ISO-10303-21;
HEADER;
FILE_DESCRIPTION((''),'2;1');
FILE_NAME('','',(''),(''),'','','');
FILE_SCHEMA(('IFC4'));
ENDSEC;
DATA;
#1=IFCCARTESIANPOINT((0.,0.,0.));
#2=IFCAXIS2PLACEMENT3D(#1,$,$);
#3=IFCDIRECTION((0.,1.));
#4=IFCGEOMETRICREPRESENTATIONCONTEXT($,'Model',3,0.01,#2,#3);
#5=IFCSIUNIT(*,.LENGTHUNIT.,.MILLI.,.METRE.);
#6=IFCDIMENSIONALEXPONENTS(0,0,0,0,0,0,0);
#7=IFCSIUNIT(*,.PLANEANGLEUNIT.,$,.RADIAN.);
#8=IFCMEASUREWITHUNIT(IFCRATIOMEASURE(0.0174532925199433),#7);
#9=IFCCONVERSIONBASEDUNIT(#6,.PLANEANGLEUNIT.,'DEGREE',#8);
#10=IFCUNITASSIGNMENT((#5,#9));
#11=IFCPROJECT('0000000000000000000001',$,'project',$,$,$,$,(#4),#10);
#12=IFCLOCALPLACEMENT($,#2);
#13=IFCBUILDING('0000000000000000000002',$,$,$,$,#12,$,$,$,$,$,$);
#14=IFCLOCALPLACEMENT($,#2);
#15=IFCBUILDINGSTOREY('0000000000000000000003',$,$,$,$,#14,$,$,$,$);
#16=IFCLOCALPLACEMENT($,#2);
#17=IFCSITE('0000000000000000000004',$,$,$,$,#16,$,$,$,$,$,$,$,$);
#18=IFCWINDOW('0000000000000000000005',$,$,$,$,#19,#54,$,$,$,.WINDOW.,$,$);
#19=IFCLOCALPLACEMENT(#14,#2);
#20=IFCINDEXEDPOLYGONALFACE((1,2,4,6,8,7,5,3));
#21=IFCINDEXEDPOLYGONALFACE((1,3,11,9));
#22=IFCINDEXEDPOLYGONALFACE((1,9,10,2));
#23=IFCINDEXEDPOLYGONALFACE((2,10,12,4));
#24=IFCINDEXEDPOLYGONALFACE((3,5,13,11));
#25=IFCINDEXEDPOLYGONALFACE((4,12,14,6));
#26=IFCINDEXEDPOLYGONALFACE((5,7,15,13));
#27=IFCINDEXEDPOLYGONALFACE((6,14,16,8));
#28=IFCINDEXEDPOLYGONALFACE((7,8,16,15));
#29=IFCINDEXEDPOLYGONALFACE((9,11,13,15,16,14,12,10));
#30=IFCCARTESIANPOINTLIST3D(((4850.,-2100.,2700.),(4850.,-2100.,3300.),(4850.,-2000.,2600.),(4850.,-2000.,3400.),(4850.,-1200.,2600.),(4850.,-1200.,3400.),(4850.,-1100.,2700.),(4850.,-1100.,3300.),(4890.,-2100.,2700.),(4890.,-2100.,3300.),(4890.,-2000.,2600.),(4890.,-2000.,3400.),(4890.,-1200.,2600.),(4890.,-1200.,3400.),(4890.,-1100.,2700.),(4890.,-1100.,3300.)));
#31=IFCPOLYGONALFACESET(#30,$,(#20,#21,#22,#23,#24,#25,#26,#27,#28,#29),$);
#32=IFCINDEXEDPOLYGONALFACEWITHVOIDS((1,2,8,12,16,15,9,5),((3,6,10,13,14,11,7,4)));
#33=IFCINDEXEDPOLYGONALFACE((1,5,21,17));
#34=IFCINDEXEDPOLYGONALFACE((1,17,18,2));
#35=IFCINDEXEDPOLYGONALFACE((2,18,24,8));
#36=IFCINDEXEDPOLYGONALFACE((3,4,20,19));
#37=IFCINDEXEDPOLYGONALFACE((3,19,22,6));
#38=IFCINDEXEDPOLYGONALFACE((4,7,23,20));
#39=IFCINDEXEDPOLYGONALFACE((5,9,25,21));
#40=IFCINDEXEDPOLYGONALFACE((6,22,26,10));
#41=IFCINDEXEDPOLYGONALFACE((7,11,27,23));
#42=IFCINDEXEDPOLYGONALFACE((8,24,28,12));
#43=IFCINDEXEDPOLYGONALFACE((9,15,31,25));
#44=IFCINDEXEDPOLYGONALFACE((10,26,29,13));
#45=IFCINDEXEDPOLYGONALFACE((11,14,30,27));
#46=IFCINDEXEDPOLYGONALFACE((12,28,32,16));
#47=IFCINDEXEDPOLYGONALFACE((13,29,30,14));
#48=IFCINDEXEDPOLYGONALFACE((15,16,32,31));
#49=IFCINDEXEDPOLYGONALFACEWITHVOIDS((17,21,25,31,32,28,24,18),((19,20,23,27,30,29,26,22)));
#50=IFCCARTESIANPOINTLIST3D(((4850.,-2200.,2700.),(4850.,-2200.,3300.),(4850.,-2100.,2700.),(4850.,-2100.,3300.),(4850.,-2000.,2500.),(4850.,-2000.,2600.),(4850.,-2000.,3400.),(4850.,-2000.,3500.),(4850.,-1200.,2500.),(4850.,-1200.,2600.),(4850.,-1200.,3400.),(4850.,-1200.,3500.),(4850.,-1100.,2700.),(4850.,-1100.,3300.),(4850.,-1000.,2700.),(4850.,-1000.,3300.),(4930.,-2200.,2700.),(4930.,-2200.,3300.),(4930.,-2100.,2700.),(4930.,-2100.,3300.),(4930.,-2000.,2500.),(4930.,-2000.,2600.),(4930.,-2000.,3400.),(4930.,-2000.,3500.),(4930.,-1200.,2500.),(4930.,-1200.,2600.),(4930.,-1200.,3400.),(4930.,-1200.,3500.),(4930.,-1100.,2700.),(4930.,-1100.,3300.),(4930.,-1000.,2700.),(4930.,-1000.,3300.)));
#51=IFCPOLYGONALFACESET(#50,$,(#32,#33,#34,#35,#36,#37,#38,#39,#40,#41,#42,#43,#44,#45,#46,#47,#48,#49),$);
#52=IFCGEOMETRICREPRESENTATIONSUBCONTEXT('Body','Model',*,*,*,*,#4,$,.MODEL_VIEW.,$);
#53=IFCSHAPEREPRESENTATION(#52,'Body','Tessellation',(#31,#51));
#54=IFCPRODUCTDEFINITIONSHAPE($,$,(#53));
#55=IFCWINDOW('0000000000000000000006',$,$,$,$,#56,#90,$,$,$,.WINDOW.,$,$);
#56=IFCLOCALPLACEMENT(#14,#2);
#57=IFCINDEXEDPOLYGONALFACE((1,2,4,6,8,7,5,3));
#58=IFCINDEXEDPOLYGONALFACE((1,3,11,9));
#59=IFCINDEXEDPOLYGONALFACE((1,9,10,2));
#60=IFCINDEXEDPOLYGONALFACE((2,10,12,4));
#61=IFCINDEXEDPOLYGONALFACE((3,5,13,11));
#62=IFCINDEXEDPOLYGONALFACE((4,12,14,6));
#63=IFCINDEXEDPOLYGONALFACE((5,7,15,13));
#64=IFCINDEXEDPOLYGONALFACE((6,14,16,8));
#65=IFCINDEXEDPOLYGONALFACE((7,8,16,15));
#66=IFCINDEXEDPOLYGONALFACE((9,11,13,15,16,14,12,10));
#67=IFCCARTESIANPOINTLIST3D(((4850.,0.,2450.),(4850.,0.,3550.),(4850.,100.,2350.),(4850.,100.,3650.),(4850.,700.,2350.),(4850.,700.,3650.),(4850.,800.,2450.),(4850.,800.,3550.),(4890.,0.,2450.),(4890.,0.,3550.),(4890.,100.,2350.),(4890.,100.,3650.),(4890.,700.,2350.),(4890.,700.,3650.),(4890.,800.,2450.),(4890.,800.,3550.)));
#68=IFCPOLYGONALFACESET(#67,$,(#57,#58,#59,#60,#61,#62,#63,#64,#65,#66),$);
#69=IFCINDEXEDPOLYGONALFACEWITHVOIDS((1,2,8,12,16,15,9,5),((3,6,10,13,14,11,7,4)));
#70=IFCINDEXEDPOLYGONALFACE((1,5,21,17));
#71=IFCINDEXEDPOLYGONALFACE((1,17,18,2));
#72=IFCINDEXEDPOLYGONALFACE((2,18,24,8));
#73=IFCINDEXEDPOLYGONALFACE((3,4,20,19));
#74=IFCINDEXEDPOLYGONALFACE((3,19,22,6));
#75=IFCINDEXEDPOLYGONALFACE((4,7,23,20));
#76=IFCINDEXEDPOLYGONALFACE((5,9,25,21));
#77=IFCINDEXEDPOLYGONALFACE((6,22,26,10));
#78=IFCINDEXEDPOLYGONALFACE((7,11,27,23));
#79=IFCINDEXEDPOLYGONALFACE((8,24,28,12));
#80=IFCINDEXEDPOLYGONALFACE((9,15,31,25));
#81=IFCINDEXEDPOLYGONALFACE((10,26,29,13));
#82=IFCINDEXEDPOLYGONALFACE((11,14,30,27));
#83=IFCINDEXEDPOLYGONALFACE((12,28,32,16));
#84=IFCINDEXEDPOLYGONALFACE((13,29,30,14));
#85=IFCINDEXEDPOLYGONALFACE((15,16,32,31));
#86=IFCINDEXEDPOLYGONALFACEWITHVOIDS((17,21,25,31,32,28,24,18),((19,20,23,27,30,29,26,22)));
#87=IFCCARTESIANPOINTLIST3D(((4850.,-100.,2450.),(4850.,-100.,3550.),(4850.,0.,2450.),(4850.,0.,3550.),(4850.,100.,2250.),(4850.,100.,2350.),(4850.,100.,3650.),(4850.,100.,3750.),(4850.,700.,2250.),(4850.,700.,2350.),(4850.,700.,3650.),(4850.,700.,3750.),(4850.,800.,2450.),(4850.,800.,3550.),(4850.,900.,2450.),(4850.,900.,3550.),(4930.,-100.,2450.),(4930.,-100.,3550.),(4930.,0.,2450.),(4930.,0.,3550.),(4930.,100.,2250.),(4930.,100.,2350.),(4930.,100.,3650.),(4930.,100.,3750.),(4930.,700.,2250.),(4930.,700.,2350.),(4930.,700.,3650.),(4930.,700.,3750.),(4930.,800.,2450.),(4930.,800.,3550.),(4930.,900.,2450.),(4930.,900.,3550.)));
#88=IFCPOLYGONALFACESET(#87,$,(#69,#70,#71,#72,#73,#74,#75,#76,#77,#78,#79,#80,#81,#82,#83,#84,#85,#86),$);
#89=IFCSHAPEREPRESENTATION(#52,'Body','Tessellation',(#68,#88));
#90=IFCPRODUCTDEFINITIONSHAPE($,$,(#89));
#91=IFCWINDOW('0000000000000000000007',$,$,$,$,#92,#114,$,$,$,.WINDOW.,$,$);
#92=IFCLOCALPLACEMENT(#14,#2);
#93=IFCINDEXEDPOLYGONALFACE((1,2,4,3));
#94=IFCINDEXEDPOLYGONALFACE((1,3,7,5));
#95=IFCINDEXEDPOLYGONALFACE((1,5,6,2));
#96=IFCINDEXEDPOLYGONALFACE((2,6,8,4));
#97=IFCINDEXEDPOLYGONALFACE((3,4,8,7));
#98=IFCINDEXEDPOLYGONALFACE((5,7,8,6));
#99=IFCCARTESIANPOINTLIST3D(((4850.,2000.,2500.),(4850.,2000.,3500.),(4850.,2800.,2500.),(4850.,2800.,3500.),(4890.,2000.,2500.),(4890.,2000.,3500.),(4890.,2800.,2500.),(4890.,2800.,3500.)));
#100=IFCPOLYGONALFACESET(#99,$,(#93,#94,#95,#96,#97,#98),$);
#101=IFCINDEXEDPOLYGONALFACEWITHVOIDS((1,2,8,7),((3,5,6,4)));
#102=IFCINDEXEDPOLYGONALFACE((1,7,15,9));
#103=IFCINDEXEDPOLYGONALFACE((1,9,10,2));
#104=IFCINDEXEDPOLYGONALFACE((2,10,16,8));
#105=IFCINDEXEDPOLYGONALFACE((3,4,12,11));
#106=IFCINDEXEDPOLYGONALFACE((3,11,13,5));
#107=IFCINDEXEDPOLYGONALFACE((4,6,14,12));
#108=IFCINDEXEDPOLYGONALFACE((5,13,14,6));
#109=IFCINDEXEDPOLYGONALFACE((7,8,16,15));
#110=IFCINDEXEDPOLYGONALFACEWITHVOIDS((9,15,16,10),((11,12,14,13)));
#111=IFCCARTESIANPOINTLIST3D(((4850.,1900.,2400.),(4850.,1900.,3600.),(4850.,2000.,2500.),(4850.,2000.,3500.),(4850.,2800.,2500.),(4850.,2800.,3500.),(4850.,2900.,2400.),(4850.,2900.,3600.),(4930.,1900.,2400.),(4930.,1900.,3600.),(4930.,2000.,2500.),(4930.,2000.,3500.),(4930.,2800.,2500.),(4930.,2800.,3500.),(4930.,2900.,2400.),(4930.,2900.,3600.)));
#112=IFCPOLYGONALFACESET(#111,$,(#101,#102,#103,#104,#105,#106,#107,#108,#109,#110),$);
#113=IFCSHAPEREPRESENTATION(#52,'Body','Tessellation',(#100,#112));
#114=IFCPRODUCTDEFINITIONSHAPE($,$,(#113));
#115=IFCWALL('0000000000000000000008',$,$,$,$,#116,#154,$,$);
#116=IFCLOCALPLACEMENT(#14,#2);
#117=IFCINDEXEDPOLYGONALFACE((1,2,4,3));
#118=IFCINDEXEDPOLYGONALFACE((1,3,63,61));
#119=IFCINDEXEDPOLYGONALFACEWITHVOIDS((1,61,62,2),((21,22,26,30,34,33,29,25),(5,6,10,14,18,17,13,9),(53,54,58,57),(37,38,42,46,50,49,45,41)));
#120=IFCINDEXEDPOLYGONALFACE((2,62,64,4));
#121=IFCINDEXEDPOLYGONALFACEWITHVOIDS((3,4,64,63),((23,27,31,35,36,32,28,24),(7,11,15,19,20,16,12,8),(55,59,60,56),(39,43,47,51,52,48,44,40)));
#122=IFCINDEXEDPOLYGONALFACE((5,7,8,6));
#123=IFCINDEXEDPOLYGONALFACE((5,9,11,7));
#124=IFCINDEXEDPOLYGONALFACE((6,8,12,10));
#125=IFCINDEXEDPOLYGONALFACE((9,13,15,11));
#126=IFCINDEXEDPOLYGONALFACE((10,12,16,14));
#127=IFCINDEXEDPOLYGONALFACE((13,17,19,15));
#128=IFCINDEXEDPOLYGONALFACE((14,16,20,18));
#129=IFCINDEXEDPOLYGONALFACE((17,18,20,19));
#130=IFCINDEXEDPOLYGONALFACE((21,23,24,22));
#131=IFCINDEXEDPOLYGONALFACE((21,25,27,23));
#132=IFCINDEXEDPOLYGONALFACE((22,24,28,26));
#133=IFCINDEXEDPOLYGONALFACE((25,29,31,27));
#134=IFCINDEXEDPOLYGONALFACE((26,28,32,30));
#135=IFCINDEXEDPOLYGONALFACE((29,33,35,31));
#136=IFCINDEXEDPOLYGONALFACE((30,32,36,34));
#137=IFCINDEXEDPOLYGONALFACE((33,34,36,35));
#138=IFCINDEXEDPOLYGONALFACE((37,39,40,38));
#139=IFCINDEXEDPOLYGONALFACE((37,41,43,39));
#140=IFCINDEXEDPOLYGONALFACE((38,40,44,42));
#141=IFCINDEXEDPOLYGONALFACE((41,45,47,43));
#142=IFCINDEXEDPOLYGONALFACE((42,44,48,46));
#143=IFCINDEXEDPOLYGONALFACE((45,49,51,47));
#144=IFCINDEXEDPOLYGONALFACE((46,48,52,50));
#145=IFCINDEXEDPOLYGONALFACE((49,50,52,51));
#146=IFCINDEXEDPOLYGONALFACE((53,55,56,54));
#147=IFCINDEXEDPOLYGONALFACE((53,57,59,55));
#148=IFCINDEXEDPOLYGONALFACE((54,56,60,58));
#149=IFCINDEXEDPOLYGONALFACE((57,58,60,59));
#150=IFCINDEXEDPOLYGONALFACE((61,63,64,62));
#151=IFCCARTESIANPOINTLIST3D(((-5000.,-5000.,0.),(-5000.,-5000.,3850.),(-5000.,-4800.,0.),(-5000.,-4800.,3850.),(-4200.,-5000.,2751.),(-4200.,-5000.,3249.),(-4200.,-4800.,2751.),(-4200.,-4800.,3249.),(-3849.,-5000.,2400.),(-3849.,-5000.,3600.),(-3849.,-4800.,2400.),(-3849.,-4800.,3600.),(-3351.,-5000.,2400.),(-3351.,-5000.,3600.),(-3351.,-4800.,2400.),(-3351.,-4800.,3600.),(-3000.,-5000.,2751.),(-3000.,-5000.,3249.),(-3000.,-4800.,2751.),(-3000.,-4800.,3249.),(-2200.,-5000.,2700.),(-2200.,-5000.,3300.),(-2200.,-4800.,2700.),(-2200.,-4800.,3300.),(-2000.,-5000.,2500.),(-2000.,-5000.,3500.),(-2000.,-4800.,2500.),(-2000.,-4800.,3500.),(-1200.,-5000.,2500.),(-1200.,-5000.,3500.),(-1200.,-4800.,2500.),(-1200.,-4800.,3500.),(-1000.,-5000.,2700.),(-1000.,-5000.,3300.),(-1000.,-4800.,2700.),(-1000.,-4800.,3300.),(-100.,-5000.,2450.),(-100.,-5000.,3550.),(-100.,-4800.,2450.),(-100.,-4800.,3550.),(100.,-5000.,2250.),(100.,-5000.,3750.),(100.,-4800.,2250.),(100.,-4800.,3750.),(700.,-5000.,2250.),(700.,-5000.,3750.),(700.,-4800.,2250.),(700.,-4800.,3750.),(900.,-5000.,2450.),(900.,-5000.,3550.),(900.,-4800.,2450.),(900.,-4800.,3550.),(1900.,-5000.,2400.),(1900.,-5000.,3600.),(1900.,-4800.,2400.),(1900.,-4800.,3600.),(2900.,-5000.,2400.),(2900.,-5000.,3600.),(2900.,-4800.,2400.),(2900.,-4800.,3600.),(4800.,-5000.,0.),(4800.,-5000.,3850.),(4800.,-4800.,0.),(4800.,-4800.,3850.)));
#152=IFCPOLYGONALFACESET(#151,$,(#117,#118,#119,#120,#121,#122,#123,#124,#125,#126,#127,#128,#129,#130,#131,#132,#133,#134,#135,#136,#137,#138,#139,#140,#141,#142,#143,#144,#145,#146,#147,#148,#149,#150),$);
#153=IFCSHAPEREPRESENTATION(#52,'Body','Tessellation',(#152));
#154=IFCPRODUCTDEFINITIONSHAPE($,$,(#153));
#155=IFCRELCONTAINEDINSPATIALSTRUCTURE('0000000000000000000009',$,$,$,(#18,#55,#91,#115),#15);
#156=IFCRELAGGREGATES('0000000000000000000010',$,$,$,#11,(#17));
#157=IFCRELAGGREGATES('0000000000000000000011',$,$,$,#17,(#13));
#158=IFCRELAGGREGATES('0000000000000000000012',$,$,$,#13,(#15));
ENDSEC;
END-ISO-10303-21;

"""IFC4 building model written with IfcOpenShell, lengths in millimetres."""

from ifc_helpers import new_model, entity, si_unit, converted_unit, direction, frame, origin, origin_2d, place, context, subcontext, project, spatial, polyline, rectangle, outline, extrude, element, save


model = new_model("IFC4")

# Units and contexts
model_context = context("Model", 3, precision=0.01, world=origin(), true_north=direction((0.0, 1.0)))
body_context = subcontext(model_context, "Body", "Model", "MODEL_VIEW")
ifc_project = project(units=[si_unit("LENGTHUNIT", "METRE", prefix="MILLI"), converted_unit("PLANEANGLEUNIT", "DEGREE", entity("IfcRatioMeasure", 0.0174532925199433), si_unit("PLANEANGLEUNIT", "RADIAN"), dimensions=[0, 0, 0, 0, 0, 0, 0])], contexts=[model_context])

# Site, building, storey
site_placement = place(None, origin())
site = spatial("IfcSite", under=ifc_project, at=site_placement)
building_placement = place(None, origin())
building = spatial("IfcBuilding", under=site, at=building_placement)
storey_placement = place(None, origin())
storey = spatial("IfcBuildingStorey", under=building, at=storey_placement)

# Shared definitions
cartesian_point_1 = entity("IfcCartesianPoint", [-500.0, -300.0])
shared_polyline_1 = entity("IfcPolyline", [cartesian_point_1, entity("IfcCartesianPoint", [-500.0, 300.0]), entity("IfcCartesianPoint", [-400.0, 400.0]), entity("IfcCartesianPoint", [400.0, 400.0]), entity("IfcCartesianPoint", [500.0, 300.0]), entity("IfcCartesianPoint", [500.0, -300.0]), entity("IfcCartesianPoint", [400.0, -400.0]), entity("IfcCartesianPoint", [-400.0, -400.0]), cartesian_point_1])
cartesian_point_2 = entity("IfcCartesianPoint", [-400.0, -550.0])
shared_polyline_2 = entity("IfcPolyline", [cartesian_point_2, entity("IfcCartesianPoint", [-400.0, 550.0]), entity("IfcCartesianPoint", [-300.0, 650.0]), entity("IfcCartesianPoint", [300.0, 650.0]), entity("IfcCartesianPoint", [400.0, 550.0]), entity("IfcCartesianPoint", [400.0, -550.0]), entity("IfcCartesianPoint", [300.0, -650.0]), entity("IfcCartesianPoint", [-300.0, -650.0]), cartesian_point_2])
cartesian_point_3 = entity("IfcCartesianPoint", [-400.0, -500.0])
shared_polyline_3 = entity("IfcPolyline", [cartesian_point_3, entity("IfcCartesianPoint", [-400.0, 500.0]), entity("IfcCartesianPoint", [-400.0, 500.0]), entity("IfcCartesianPoint", [400.0, 500.0]), entity("IfcCartesianPoint", [400.0, 500.0]), entity("IfcCartesianPoint", [400.0, -500.0]), entity("IfcCartesianPoint", [400.0, -500.0]), entity("IfcCartesianPoint", [-400.0, -500.0]), cartesian_point_3])

# Shared definitions
wall_1_placement = place(storey_placement, frame((4900.0, -100.0, 0.0), z_axis=(0.0, 0.0, 1.0), x_axis=(0.0, 1.0, 0.0)))
window_1_placement = place(wall_1_placement, frame((-1500.0, 50.0, 3000.0)))
window_2_placement = place(wall_1_placement, frame((500.0, 50.0, 3000.0)))
window_3_placement = place(wall_1_placement, frame((2500.0, 50.0, 3000.0)))

# Windows
cartesian_point_4 = entity("IfcCartesianPoint", [-600.0, -300.0])
element("IfcWindow", 1, at=window_1_placement, inside=storey, PredefinedType="WINDOW", context=body_context, shape_type="SweptSolid", body=[
    entity("IfcExtrudedAreaSolid", entity("IfcArbitraryClosedProfileDef", "AREA", None, shared_polyline_1), entity("IfcAxis2Placement3D", entity("IfcCartesianPoint", [0.0, 0.0, 0.0]), entity("IfcDirection", [0.0, -1.0, 0.0]), entity("IfcDirection", [1.0, 0.0, 0.0])), entity("IfcDirection", [0.0, 0.0, 1.0]), 40.0),
    entity("IfcExtrudedAreaSolid", entity("IfcArbitraryProfileDefWithVoids", "AREA", None, entity("IfcPolyline", [cartesian_point_4, entity("IfcCartesianPoint", [-600.0, 300.0]), entity("IfcCartesianPoint", [-400.0, 500.0]), entity("IfcCartesianPoint", [400.0, 500.0]), entity("IfcCartesianPoint", [600.0, 300.0]), entity("IfcCartesianPoint", [600.0, -300.0]), entity("IfcCartesianPoint", [400.0, -500.0]), entity("IfcCartesianPoint", [-400.0, -500.0]), cartesian_point_4]), [shared_polyline_1]), entity("IfcAxis2Placement3D", entity("IfcCartesianPoint", [0.0, 0.0, 0.0]), entity("IfcDirection", [0.0, -1.0, 0.0]), entity("IfcDirection", [1.0, 0.0, 0.0])), entity("IfcDirection", [0.0, 0.0, 1.0]), 80.0),
])
cartesian_point_5 = entity("IfcCartesianPoint", [-500.0, -550.0])
element("IfcWindow", 2, at=window_2_placement, inside=storey, PredefinedType="WINDOW", context=body_context, shape_type="SweptSolid", body=[
    entity("IfcExtrudedAreaSolid", entity("IfcArbitraryClosedProfileDef", "AREA", None, shared_polyline_2), entity("IfcAxis2Placement3D", entity("IfcCartesianPoint", [0.0, 0.0, 0.0]), entity("IfcDirection", [0.0, -1.0, 0.0]), entity("IfcDirection", [1.0, 0.0, 0.0])), entity("IfcDirection", [0.0, 0.0, 1.0]), 40.0),
    entity("IfcExtrudedAreaSolid", entity("IfcArbitraryProfileDefWithVoids", "AREA", None, entity("IfcPolyline", [cartesian_point_5, entity("IfcCartesianPoint", [-500.0, 550.0]), entity("IfcCartesianPoint", [-300.0, 750.0]), entity("IfcCartesianPoint", [300.0, 750.0]), entity("IfcCartesianPoint", [500.0, 550.0]), entity("IfcCartesianPoint", [500.0, -550.0]), entity("IfcCartesianPoint", [300.0, -750.0]), entity("IfcCartesianPoint", [-300.0, -750.0]), cartesian_point_5]), [shared_polyline_2]), entity("IfcAxis2Placement3D", entity("IfcCartesianPoint", [0.0, 0.0, 0.0]), entity("IfcDirection", [0.0, -1.0, 0.0]), entity("IfcDirection", [1.0, 0.0, 0.0])), entity("IfcDirection", [0.0, 0.0, 1.0]), 80.0),
])
cartesian_point_6 = entity("IfcCartesianPoint", [-500.0, -600.0])
element("IfcWindow", 3, at=window_3_placement, inside=storey, PredefinedType="WINDOW", context=body_context, shape_type="SweptSolid", body=[
    entity("IfcExtrudedAreaSolid", entity("IfcArbitraryClosedProfileDef", "AREA", None, shared_polyline_3), entity("IfcAxis2Placement3D", entity("IfcCartesianPoint", [0.0, 0.0, 0.0]), entity("IfcDirection", [0.0, -1.0, 0.0]), entity("IfcDirection", [1.0, 0.0, 0.0])), entity("IfcDirection", [0.0, 0.0, 1.0]), 40.0),
    entity("IfcExtrudedAreaSolid", entity("IfcArbitraryProfileDefWithVoids", "AREA", None, entity("IfcPolyline", [cartesian_point_6, entity("IfcCartesianPoint", [-500.0, 600.0]), entity("IfcCartesianPoint", [-500.0, 600.0]), entity("IfcCartesianPoint", [500.0, 600.0]), entity("IfcCartesianPoint", [500.0, 600.0]), entity("IfcCartesianPoint", [500.0, -600.0]), entity("IfcCartesianPoint", [500.0, -600.0]), entity("IfcCartesianPoint", [-500.0, -600.0]), cartesian_point_6]), [shared_polyline_3]), entity("IfcAxis2Placement3D", entity("IfcCartesianPoint", [0.0, 0.0, 0.0]), entity("IfcDirection", [0.0, -1.0, 0.0]), entity("IfcDirection", [1.0, 0.0, 0.0])), entity("IfcDirection", [0.0, 0.0, 1.0]), 80.0),
])

# Wall, openings
wall_2_placement = place(storey_placement, frame((-100.0, -4900.0, 0.0), z_axis=(0.0, 0.0, 1.0), x_axis=(1.0, 0.0, 0.0)))
wall_2 = element("IfcWall", 4, at=wall_2_placement, inside=storey, context=body_context, shape_type="SweptSolid", body=[
    extrude(rectangle(XDim=9800.0, YDim=200.0, at=origin_2d()), origin(), (0.0, 0.0, 1.0), 3850.0),
])
window_4_placement = place(wall_2_placement, frame((-3500.0, 50.0, 3000.0)))
opening_1_placement = place(window_4_placement, frame((0.0, 50.0, 0.0)))
element("IfcOpeningElement", 5, at=opening_1_placement, cuts=wall_2, context=body_context, shape_type="SweptSolid", body=[
    extrude(outline(polyline([(-600.0, -249.0), (-600.0, 249.0), (-249.0, 600.0), (249.0, 600.0), (600.0, 249.0), (600.0, -249.0), (249.0, -600.0), (-249.0, -600.0), (-600.0, -249.0)])), frame((0.0, 0.0, 0.0), z_axis=(0.0, -1.0, 0.0), x_axis=(1.0, 0.0, 0.0)), (0.0, 0.0, 1.0), 200.0),
])
window_5_placement = place(wall_2_placement, frame((-1500.0, 50.0, 3000.0)))
opening_2_placement = place(window_5_placement, frame((0.0, 50.0, 0.0)))
element("IfcOpeningElement", 6, at=opening_2_placement, cuts=wall_2, context=body_context, shape_type="SweptSolid", body=[
    extrude(outline(polyline([(-600.0, -300.0), (-600.0, 300.0), (-400.0, 500.0), (400.0, 500.0), (600.0, 300.0), (600.0, -300.0), (400.0, -500.0), (-400.0, -500.0), (-600.0, -300.0)])), frame((0.0, 0.0, 0.0), z_axis=(0.0, -1.0, 0.0), x_axis=(1.0, 0.0, 0.0)), (0.0, 0.0, 1.0), 200.0),
])
window_6_placement = place(wall_2_placement, frame((500.0, 50.0, 3000.0)))
opening_3_placement = place(window_6_placement, frame((0.0, 50.0, 0.0)))
element("IfcOpeningElement", 7, at=opening_3_placement, cuts=wall_2, context=body_context, shape_type="SweptSolid", body=[
    extrude(outline(polyline([(-500.0, -550.0), (-500.0, 550.0), (-300.0, 750.0), (300.0, 750.0), (500.0, 550.0), (500.0, -550.0), (300.0, -750.0), (-300.0, -750.0), (-500.0, -550.0)])), frame((0.0, 0.0, 0.0), z_axis=(0.0, -1.0, 0.0), x_axis=(1.0, 0.0, 0.0)), (0.0, 0.0, 1.0), 200.0),
])
window_7_placement = place(wall_2_placement, frame((2500.0, 50.0, 3000.0)))
opening_4_placement = place(window_7_placement, frame((0.0, 50.0, 0.0)))
element("IfcOpeningElement", 8, at=opening_4_placement, cuts=wall_2, context=body_context, shape_type="SweptSolid", body=[
    extrude(outline(polyline([(-500.0, -600.0), (-500.0, 600.0), (-500.0, 600.0), (500.0, 600.0), (500.0, 600.0), (500.0, -600.0), (500.0, -600.0), (-500.0, -600.0), (-500.0, -600.0)])), frame((0.0, 0.0, 0.0), z_axis=(0.0, -1.0, 0.0), x_axis=(1.0, 0.0, 0.0)), (0.0, 0.0, 1.0), 200.0),
])

save(model, "model.ifc")
